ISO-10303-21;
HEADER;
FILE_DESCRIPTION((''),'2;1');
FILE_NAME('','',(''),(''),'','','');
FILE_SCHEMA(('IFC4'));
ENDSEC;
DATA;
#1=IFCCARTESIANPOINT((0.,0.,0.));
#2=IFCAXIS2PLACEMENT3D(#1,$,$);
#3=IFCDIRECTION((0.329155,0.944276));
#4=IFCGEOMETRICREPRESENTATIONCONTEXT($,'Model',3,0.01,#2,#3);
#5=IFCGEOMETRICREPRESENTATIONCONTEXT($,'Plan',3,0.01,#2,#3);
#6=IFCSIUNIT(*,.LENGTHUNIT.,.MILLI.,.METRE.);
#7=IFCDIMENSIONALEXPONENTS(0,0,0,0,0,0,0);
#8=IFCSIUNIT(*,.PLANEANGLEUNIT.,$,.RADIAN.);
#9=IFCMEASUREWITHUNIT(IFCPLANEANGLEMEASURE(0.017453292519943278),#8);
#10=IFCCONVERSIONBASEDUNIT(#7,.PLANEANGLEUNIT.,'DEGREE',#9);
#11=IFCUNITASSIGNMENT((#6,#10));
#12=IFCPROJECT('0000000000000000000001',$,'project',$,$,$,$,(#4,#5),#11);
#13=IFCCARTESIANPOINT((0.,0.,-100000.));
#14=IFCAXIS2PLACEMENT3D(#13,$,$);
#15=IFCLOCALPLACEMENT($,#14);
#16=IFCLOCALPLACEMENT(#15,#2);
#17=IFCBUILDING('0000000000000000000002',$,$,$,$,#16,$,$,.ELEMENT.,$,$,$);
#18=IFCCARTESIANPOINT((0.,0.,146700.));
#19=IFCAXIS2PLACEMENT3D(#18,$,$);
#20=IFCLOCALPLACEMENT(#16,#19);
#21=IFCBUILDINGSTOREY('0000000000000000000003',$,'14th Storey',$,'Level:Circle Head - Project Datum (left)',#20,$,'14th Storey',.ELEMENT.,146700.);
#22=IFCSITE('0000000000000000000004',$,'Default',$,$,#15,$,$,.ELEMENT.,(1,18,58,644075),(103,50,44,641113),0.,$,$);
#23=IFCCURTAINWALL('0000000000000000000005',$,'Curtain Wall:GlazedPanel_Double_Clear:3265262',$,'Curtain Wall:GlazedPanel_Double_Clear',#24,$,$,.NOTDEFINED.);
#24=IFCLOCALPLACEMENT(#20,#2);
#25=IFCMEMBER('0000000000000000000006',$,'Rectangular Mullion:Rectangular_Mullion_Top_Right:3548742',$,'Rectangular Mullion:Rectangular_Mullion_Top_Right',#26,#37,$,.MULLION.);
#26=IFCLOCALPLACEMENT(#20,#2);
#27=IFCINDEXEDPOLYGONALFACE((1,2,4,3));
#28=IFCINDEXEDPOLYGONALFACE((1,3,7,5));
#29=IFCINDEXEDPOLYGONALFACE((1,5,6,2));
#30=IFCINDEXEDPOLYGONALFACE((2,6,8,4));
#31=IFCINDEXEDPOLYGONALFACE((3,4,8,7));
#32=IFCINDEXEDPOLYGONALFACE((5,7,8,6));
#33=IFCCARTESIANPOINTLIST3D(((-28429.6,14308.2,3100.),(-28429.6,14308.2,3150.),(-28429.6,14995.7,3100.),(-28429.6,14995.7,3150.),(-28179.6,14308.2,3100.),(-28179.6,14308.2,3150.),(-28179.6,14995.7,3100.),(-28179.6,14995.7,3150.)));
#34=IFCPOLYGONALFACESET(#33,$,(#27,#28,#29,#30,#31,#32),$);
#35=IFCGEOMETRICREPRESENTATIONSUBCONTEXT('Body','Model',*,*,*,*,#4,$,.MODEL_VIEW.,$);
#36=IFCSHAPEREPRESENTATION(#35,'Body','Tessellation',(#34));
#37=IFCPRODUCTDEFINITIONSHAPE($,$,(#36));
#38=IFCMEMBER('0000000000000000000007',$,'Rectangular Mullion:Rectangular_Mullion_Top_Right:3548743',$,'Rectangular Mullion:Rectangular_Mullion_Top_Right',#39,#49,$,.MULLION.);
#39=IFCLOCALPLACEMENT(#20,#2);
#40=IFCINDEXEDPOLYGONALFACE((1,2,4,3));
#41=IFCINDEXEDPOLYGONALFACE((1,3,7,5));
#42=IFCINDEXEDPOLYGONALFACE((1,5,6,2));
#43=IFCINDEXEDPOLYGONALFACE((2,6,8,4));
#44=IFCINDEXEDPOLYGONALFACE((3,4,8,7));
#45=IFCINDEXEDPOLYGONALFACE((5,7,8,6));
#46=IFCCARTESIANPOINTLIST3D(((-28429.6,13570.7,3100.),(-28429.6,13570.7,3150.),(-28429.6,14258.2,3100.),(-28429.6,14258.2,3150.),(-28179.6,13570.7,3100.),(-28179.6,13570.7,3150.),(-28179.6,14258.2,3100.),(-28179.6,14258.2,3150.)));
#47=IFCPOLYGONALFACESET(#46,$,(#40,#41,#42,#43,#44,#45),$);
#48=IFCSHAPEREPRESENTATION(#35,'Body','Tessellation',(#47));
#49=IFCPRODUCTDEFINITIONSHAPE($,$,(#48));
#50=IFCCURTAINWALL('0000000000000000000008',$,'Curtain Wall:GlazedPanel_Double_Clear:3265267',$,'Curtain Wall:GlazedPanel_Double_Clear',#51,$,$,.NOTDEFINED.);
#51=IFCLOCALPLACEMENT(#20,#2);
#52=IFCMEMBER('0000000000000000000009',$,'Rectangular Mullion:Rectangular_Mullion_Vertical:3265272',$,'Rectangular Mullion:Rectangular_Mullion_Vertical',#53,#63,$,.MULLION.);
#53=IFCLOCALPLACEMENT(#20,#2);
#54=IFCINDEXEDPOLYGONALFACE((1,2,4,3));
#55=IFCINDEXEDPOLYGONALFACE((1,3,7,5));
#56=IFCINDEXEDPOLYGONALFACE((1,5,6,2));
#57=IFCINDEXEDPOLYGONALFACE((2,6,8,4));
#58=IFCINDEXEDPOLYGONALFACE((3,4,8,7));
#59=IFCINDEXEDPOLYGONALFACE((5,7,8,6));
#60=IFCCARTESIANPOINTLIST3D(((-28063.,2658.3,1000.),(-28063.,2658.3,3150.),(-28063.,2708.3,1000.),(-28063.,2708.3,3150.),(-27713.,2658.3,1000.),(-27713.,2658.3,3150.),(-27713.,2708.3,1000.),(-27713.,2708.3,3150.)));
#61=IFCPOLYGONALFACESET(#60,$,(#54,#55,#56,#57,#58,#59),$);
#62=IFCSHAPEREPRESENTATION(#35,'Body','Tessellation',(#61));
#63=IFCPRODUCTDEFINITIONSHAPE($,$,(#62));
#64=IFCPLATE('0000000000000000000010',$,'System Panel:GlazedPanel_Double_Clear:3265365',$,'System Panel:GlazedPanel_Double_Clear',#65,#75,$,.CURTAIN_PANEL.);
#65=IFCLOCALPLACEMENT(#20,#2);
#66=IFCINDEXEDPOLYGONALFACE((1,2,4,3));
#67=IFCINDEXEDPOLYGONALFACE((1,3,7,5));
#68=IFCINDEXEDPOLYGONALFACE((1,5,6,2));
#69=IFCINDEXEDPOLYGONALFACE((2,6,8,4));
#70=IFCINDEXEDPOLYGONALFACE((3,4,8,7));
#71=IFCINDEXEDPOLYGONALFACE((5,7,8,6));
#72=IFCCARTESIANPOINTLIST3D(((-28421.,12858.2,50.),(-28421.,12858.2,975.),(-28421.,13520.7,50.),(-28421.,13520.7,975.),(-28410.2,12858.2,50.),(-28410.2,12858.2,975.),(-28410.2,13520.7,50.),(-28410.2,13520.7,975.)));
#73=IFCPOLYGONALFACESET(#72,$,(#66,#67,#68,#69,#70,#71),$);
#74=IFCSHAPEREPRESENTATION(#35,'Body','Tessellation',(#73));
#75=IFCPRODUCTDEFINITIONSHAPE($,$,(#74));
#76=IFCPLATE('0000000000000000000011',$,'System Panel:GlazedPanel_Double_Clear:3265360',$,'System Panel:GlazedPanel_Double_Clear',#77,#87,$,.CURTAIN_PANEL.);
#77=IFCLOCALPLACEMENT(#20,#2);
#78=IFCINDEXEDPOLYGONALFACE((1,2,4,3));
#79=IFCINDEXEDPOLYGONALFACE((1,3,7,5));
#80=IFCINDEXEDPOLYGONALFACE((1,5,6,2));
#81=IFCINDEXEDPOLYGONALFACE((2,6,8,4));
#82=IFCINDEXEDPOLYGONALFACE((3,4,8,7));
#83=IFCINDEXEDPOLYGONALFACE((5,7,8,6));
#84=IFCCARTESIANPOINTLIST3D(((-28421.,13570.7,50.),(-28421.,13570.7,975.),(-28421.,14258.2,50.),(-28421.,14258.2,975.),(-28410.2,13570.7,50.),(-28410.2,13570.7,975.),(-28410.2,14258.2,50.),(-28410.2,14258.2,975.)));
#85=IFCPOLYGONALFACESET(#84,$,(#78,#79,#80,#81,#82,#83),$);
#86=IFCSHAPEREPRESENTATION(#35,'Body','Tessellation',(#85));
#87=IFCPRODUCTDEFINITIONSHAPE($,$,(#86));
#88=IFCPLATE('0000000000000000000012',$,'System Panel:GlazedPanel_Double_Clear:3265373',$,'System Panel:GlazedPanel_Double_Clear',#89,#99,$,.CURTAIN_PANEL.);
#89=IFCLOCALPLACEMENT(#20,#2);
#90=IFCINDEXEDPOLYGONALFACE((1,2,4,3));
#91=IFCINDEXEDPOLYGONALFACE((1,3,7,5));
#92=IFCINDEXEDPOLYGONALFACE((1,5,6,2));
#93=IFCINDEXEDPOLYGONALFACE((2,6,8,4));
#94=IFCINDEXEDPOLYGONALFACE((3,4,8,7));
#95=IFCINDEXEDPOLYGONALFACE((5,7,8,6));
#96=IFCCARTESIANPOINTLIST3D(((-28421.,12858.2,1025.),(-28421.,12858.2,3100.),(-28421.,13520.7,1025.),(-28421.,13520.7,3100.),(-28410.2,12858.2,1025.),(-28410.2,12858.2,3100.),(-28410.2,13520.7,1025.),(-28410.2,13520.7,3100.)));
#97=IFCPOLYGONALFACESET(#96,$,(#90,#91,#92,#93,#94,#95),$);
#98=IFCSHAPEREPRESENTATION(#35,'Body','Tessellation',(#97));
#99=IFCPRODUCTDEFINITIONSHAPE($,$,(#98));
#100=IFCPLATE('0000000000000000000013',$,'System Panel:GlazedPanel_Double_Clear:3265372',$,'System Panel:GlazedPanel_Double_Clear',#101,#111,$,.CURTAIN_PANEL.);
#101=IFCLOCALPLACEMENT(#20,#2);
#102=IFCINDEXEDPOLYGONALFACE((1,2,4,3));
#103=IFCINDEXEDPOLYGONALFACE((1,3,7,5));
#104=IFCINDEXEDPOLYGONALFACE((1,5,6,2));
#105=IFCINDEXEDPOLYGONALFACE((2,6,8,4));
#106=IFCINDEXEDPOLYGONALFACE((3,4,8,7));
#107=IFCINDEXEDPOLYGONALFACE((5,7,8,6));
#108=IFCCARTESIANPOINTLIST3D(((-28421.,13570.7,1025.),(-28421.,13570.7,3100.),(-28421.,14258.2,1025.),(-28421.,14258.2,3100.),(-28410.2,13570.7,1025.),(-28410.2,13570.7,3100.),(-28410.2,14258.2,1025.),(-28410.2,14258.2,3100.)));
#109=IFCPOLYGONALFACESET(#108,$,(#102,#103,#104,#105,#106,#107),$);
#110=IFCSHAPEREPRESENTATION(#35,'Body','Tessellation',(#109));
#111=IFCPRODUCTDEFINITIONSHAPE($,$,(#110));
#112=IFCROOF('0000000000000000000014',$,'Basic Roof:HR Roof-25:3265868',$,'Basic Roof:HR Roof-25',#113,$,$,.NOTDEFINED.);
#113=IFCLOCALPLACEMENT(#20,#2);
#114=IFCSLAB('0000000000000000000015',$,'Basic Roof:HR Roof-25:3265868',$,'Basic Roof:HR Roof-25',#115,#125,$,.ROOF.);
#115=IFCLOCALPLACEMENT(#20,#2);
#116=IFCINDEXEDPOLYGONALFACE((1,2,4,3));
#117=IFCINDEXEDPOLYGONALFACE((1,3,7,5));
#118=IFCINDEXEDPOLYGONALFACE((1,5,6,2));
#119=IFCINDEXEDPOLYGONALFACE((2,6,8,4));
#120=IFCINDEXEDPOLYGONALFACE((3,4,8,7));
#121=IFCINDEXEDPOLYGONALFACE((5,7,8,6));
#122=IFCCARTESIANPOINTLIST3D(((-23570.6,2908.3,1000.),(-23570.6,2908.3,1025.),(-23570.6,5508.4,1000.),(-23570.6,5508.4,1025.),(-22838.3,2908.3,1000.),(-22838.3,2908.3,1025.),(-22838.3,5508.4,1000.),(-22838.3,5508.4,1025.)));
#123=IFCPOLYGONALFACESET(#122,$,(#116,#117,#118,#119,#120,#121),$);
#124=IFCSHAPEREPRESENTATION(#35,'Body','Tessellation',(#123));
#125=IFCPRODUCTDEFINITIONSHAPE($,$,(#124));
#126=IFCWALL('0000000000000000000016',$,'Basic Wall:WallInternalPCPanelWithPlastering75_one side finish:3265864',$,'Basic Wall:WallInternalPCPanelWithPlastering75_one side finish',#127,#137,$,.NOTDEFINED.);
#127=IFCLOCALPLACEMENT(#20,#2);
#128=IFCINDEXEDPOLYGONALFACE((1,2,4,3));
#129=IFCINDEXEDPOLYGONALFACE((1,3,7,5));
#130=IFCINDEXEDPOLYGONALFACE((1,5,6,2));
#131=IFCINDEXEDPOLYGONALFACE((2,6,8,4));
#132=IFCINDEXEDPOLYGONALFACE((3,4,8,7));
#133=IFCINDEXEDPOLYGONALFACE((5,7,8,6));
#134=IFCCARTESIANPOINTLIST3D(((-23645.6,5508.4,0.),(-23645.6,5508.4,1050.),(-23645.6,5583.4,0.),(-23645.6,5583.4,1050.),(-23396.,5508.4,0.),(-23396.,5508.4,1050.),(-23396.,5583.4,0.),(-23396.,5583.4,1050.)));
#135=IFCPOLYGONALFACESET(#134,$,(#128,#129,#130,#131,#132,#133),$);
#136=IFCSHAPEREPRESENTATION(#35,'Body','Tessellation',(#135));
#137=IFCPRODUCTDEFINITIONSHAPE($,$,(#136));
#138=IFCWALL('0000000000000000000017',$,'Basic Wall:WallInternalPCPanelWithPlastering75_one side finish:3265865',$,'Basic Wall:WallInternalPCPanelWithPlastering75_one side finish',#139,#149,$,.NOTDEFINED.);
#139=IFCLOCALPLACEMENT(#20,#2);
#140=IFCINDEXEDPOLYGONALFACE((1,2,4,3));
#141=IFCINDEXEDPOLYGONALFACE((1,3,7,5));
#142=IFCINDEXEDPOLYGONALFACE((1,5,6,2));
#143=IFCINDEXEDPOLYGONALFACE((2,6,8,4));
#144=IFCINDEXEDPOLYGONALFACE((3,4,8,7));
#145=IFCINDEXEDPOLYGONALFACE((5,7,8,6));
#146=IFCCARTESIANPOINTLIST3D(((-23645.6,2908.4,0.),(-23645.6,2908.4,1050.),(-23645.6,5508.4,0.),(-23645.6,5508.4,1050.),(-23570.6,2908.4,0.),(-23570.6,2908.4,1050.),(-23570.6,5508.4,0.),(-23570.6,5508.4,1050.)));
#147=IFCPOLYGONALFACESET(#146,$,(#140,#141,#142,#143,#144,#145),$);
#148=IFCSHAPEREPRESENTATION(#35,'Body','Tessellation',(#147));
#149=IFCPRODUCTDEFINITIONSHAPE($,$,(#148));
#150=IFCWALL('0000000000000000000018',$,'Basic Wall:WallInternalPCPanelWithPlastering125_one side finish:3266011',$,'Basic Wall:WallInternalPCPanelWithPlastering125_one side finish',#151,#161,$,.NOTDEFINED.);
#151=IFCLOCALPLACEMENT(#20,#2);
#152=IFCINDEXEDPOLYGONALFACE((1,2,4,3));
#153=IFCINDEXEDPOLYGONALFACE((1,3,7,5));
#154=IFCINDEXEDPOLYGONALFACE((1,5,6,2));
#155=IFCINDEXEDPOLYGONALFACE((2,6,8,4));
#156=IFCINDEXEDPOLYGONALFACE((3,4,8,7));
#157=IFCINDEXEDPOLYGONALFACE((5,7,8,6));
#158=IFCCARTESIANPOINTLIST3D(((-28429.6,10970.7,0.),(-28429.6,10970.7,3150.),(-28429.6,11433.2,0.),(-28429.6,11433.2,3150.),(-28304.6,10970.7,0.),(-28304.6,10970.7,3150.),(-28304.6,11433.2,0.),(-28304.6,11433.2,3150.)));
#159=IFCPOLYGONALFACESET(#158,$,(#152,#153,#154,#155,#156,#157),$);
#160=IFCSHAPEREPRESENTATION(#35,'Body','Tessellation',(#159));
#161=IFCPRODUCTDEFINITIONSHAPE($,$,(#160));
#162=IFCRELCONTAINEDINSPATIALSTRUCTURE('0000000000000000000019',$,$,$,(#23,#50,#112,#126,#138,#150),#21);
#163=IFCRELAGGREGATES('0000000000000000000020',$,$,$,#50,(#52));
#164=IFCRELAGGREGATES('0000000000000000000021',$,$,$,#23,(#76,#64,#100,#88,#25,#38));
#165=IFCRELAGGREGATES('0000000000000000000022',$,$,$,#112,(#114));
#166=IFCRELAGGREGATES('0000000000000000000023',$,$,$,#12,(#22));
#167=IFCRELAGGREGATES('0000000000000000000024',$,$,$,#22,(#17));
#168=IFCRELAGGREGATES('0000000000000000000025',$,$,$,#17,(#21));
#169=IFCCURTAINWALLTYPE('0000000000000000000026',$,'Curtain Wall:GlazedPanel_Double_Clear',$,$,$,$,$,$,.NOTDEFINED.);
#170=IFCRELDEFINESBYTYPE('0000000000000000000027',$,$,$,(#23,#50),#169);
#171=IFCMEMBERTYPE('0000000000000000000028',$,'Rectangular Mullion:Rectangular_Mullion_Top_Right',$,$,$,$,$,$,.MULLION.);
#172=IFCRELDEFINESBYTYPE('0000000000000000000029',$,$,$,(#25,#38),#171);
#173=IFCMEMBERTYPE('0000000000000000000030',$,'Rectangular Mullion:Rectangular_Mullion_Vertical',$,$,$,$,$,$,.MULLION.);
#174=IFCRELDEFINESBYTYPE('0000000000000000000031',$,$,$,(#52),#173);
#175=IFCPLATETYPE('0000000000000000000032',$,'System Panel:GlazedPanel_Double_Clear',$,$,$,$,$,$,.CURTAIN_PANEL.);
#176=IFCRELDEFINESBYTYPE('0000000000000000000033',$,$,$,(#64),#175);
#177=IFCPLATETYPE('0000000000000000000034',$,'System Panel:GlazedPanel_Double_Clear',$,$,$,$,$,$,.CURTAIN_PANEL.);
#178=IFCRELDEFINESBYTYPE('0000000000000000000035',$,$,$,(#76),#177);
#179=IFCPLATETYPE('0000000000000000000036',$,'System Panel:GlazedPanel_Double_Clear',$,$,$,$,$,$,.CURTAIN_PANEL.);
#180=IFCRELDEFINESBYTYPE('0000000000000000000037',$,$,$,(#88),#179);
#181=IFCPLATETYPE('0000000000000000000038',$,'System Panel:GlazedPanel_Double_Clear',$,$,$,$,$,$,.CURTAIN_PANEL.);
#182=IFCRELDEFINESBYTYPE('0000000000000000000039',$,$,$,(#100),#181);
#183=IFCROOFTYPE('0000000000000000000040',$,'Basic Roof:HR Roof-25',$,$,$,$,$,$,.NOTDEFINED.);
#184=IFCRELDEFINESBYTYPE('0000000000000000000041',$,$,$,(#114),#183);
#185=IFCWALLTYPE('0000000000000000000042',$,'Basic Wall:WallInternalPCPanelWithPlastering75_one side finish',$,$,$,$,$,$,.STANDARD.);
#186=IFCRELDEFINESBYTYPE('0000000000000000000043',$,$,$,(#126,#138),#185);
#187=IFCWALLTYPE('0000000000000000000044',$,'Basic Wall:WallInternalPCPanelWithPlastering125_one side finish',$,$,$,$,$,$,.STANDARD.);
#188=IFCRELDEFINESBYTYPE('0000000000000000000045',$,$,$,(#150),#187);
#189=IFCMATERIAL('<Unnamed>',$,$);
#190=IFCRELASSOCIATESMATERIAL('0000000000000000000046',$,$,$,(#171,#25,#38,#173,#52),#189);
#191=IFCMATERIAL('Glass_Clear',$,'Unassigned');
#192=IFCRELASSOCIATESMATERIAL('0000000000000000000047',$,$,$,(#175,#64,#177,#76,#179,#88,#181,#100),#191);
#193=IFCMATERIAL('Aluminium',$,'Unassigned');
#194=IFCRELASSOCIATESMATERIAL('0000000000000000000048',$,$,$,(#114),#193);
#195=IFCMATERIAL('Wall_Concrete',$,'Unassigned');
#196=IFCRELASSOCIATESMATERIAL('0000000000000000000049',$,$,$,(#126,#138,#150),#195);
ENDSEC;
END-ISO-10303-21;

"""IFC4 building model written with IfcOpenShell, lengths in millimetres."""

from ifc_helpers import new_model, entity, si_unit, converted_unit, direction, frame, origin, place, context, subcontext, project, spatial, indexed_curve, outline, extrude, source, transform, mapped, material, type_object, type_shapes, element, aggregate, save


model = new_model("IFC4")

# Units and contexts
model_context = context("Model", 3, precision=0.01, world=origin(), true_north=direction((0.329155, 0.944276)))
plan_context = context("Plan", 3, precision=0.01, world=origin(), true_north=direction((0.329155, 0.944276)))
body_context = subcontext(model_context, "Body", "Model", "MODEL_VIEW")
ifc_project = project(units=[si_unit("LENGTHUNIT", "METRE", prefix="MILLI"), converted_unit("PLANEANGLEUNIT", "DEGREE", entity("IfcPlaneAngleMeasure", 0.017453292519943278), si_unit("PLANEANGLEUNIT", "RADIAN"), dimensions=[0, 0, 0, 0, 0, 0, 0])], contexts=[model_context, plan_context])

# Site, building, storey
site_placement = place(None, frame((0.0, 0.0, -100000.0)))
site = spatial("IfcSite", under=ifc_project, at=site_placement, Name="Default", CompositionType="ELEMENT", RefLatitude=(1, 18, 58, 644075), RefLongitude=(103, 50, 44, 641113), RefElevation=0.0)
building_placement = place(site_placement, origin())
building = spatial("IfcBuilding", under=site, at=building_placement, CompositionType="ELEMENT")
storey_placement = place(building_placement, frame((0.0, 0.0, 146700.0)))
storey = spatial("IfcBuildingStorey", under=building, at=storey_placement, Name="14th Storey", ObjectType="Level:Circle Head - Project Datum (left)", LongName="14th Storey", CompositionType="ELEMENT", Elevation=146700.0)

# Curtain wall, members
curtain_wall_type = type_object("IfcCurtainWallType", Name="Curtain Wall:GlazedPanel_Double_Clear", PredefinedType="NOTDEFINED")
ifc_material_1 = material(Name="<Unnamed>")
curtain_wall_1_placement = place(storey_placement, frame((0.0, 0.0, -146700.0)))
curtain_wall_1 = element("IfcCurtainWall", 1, at=curtain_wall_1_placement, inside=storey, type_object=curtain_wall_type, Name="Curtain Wall:GlazedPanel_Double_Clear:3265262", ObjectType="Curtain Wall:GlazedPanel_Double_Clear", PredefinedType="NOTDEFINED")
member_type_1 = type_object("IfcMemberType", Name="Rectangular Mullion:Rectangular_Mullion_Top_Right", PredefinedType="MULLION", material=ifc_material_1)
shared_shape_1 = source(origin(), body_context, "Body", "SweptSolid", [
    extrude(outline(indexed_curve([(-25.0, -125.0), (25.0, -125.0), (25.0, 125.0), (-25.0, 125.0), (-25.0, -125.0)], self_intersect=False)), frame((-25.0, 0.0, -687.5), z_axis=(0.0, 0.0, 1.0), x_axis=(-1.0, 0.0, 0.0)), (0.0, 0.0, 1.0), 687.5),
])
type_shapes(member_type_1, [shared_shape_1])
member_1_placement = place(curtain_wall_1_placement, frame((-28304.6, 14308.2, 149850.0), z_axis=(0.0, -1.0, 0.0), x_axis=(0.0, 0.0, 1.0)))
member_1 = element("IfcMember", 2, at=member_1_placement, type_object=member_type_1, material=ifc_material_1, Name="Rectangular Mullion:Rectangular_Mullion_Top_Right:3548742", ObjectType="Rectangular Mullion:Rectangular_Mullion_Top_Right", PredefinedType="MULLION", context=body_context, shape_type="MappedRepresentation", body=[
    mapped(shared_shape_1, transform((0.0, 0.0, 0.0), scale=1.0)),
])
member_2_placement = place(curtain_wall_1_placement, frame((-28304.6, 13570.7, 149850.0), z_axis=(0.0, -1.0, 0.0), x_axis=(0.0, 0.0, 1.0)))
member_2 = element("IfcMember", 3, at=member_2_placement, type_object=member_type_1, material=ifc_material_1, Name="Rectangular Mullion:Rectangular_Mullion_Top_Right:3548743", ObjectType="Rectangular Mullion:Rectangular_Mullion_Top_Right", PredefinedType="MULLION", context=body_context, shape_type="MappedRepresentation", body=[
    mapped(shared_shape_1, transform((0.0, 0.0, 0.0), scale=1.0)),
])

# Curtain wall, member
curtain_wall_2_placement = place(storey_placement, frame((0.0, 0.0, -146700.0)))
curtain_wall_2 = element("IfcCurtainWall", 4, at=curtain_wall_2_placement, inside=storey, type_object=curtain_wall_type, Name="Curtain Wall:GlazedPanel_Double_Clear:3265267", ObjectType="Curtain Wall:GlazedPanel_Double_Clear", PredefinedType="NOTDEFINED")
member_type_2 = type_object("IfcMemberType", Name="Rectangular Mullion:Rectangular_Mullion_Vertical", PredefinedType="MULLION", material=ifc_material_1)
shared_shape_2 = source(origin(), body_context, "Body", "SweptSolid", [
    extrude(outline(indexed_curve([(-25.0, -175.0), (25.0, -175.0), (25.0, 175.0), (-25.0, 175.0), (-25.0, -175.0)], self_intersect=False)), frame((-25.0, 50.0, -2150.0), z_axis=(0.0, 0.0, 1.0), x_axis=(-1.0, 0.0, 0.0)), (0.0, 0.0, 1.0), 2150.0),
])
type_shapes(member_type_2, [shared_shape_2])
member_3_placement = place(curtain_wall_2_placement, frame((-27838.0, 2708.3, 149850.0), z_axis=(0.0, 0.0, 1.0), x_axis=(0.0, 1.0, 0.0)))
member_3 = element("IfcMember", 5, at=member_3_placement, type_object=member_type_2, material=ifc_material_1, Name="Rectangular Mullion:Rectangular_Mullion_Vertical:3265272", ObjectType="Rectangular Mullion:Rectangular_Mullion_Vertical", PredefinedType="MULLION", context=body_context, shape_type="MappedRepresentation", body=[
    mapped(shared_shape_2, transform((0.0, 0.0, 0.0), scale=1.0)),
])
aggregate(curtain_wall_2, [member_3])

# Plates
ifc_material_2 = material(Name="Glass_Clear", Category="Unassigned")
plate_type_1 = type_object("IfcPlateType", Name="System Panel:GlazedPanel_Double_Clear", PredefinedType="CURTAIN_PANEL", material=ifc_material_2)
shared_shape_3 = source(origin(), body_context, "Body", "SweptSolid", [
    extrude(outline(indexed_curve([(-5.4, -331.3), (5.4, -331.3), (5.4, 331.3), (-5.4, 331.3), (-5.4, -331.3)], self_intersect=False)), frame((331.3, 5.4, 0.0), z_axis=(0.0, 0.0, 1.0), x_axis=(0.0, 1.0, 0.0)), (0.0, 0.0, 1.0), 925.0),
])
type_shapes(plate_type_1, [shared_shape_3])
plate_1_placement = place(curtain_wall_1_placement, frame((-28421.0, 13520.7, 146750.0), z_axis=(0.0, 0.0, 1.0), x_axis=(0.0, -1.0, 0.0)))
plate_1 = element("IfcPlate", 6, at=plate_1_placement, type_object=plate_type_1, material=ifc_material_2, Name="System Panel:GlazedPanel_Double_Clear:3265365", ObjectType="System Panel:GlazedPanel_Double_Clear", PredefinedType="CURTAIN_PANEL", context=body_context, shape_type="MappedRepresentation", body=[
    mapped(shared_shape_3, transform((0.0, 0.0, 0.0), scale=1.0)),
])
plate_type_2 = type_object("IfcPlateType", Name="System Panel:GlazedPanel_Double_Clear", PredefinedType="CURTAIN_PANEL", material=ifc_material_2)
shared_shape_4 = source(origin(), body_context, "Body", "SweptSolid", [
    extrude(outline(indexed_curve([(-5.4, -343.7), (5.4, -343.7), (5.4, 343.7), (-5.4, 343.7), (-5.4, -343.7)], self_intersect=False)), frame((343.7, 5.4, 0.0), z_axis=(0.0, 0.0, 1.0), x_axis=(0.0, 1.0, 0.0)), (0.0, 0.0, 1.0), 925.0),
])
type_shapes(plate_type_2, [shared_shape_4])
plate_2_placement = place(curtain_wall_1_placement, frame((-28421.0, 14258.2, 146750.0), z_axis=(0.0, 0.0, 1.0), x_axis=(0.0, -1.0, 0.0)))
plate_2 = element("IfcPlate", 7, at=plate_2_placement, type_object=plate_type_2, material=ifc_material_2, Name="System Panel:GlazedPanel_Double_Clear:3265360", ObjectType="System Panel:GlazedPanel_Double_Clear", PredefinedType="CURTAIN_PANEL", context=body_context, shape_type="MappedRepresentation", body=[
    mapped(shared_shape_4, transform((0.0, 0.0, 0.0), scale=1.0)),
])
plate_type_3 = type_object("IfcPlateType", Name="System Panel:GlazedPanel_Double_Clear", PredefinedType="CURTAIN_PANEL", material=ifc_material_2)
shared_shape_5 = source(origin(), body_context, "Body", "SweptSolid", [
    extrude(outline(indexed_curve([(-5.4, -331.3), (5.4, -331.3), (5.4, 331.3), (-5.4, 331.3), (-5.4, -331.3)], self_intersect=False)), frame((331.3, 5.4, 0.0), z_axis=(0.0, 0.0, 1.0), x_axis=(0.0, 1.0, 0.0)), (0.0, 0.0, 1.0), 2075.0),
])
type_shapes(plate_type_3, [shared_shape_5])
plate_3_placement = place(curtain_wall_1_placement, frame((-28421.0, 13520.7, 147725.0), z_axis=(0.0, 0.0, 1.0), x_axis=(0.0, -1.0, 0.0)))
plate_3 = element("IfcPlate", 8, at=plate_3_placement, type_object=plate_type_3, material=ifc_material_2, Name="System Panel:GlazedPanel_Double_Clear:3265373", ObjectType="System Panel:GlazedPanel_Double_Clear", PredefinedType="CURTAIN_PANEL", context=body_context, shape_type="MappedRepresentation", body=[
    mapped(shared_shape_5, transform((0.0, 0.0, 0.0), scale=1.0)),
])
plate_type_4 = type_object("IfcPlateType", Name="System Panel:GlazedPanel_Double_Clear", PredefinedType="CURTAIN_PANEL", material=ifc_material_2)
shared_shape_6 = source(origin(), body_context, "Body", "SweptSolid", [
    extrude(outline(indexed_curve([(-5.4, -343.7), (5.4, -343.7), (5.4, 343.7), (-5.4, 343.7), (-5.4, -343.7)], self_intersect=False)), frame((343.7, 5.4, 0.0), z_axis=(0.0, 0.0, 1.0), x_axis=(0.0, 1.0, 0.0)), (0.0, 0.0, 1.0), 2075.0),
])
type_shapes(plate_type_4, [shared_shape_6])
plate_4_placement = place(curtain_wall_1_placement, frame((-28421.0, 14258.2, 147725.0), z_axis=(0.0, 0.0, 1.0), x_axis=(0.0, -1.0, 0.0)))
plate_4 = element("IfcPlate", 9, at=plate_4_placement, type_object=plate_type_4, material=ifc_material_2, Name="System Panel:GlazedPanel_Double_Clear:3265372", ObjectType="System Panel:GlazedPanel_Double_Clear", PredefinedType="CURTAIN_PANEL", context=body_context, shape_type="MappedRepresentation", body=[
    mapped(shared_shape_6, transform((0.0, 0.0, 0.0), scale=1.0)),
])
aggregate(curtain_wall_1, [plate_2, plate_1, plate_4, plate_3, member_1, member_2])

# Roof, slab
roof_placement = place(storey_placement, frame((-23570.6, 2908.3, 1000.0)))
roof = element("IfcRoof", 10, at=roof_placement, inside=storey, Name="Basic Roof:HR Roof-25:3265868", ObjectType="Basic Roof:HR Roof-25", PredefinedType="NOTDEFINED")
ifc_material_3 = material(Name="Aluminium", Category="Unassigned")
roof_type = type_object("IfcRoofType", Name="Basic Roof:HR Roof-25", PredefinedType="NOTDEFINED")
slab_placement = place(roof_placement, origin())
slab = element("IfcSlab", 11, at=slab_placement, type_object=roof_type, material=ifc_material_3, Name="Basic Roof:HR Roof-25:3265868", ObjectType="Basic Roof:HR Roof-25", PredefinedType="ROOF", context=body_context, shape_type="SweptSolid", body=[
    extrude(outline(indexed_curve([(-366.1, 1300.1), (-366.1, -1300.1), (366.1, -1300.1), (366.1, 1300.1), (-366.1, 1300.1)], self_intersect=False)), frame((366.1, 1300.1, 0.0)), (0.0, 0.0, 1.0), 25.0),
])
aggregate(roof, [slab])

# Walls
ifc_material_4 = material(Name="Wall_Concrete", Category="Unassigned")
wall_type_1 = type_object("IfcWallType", Name="Basic Wall:WallInternalPCPanelWithPlastering75_one side finish", PredefinedType="STANDARD")
wall_1_placement = place(storey_placement, frame((-23396.0, 5545.9, 0.0), z_axis=(0.0, 0.0, 1.0), x_axis=(-1.0, 0.0, 0.0)))
element("IfcWall", 12, at=wall_1_placement, inside=storey, type_object=wall_type_1, material=ifc_material_4, Name="Basic Wall:WallInternalPCPanelWithPlastering75_one side finish:3265864", ObjectType="Basic Wall:WallInternalPCPanelWithPlastering75_one side finish", PredefinedType="NOTDEFINED", context=body_context, shape_type="SweptSolid", body=[
    extrude(outline(indexed_curve([(249.6, 37.5), (0.0, 37.5), (0.0, -37.5), (249.6, -37.5), (249.6, 37.5)], self_intersect=False)), origin(), (0.0, 0.0, 1.0), 1050.0),
])
wall_2_placement = place(storey_placement, frame((-23608.1, 5508.4, 0.0), z_axis=(0.0, 0.0, 1.0), x_axis=(0.0, -1.0, 0.0)))
element("IfcWall", 13, at=wall_2_placement, inside=storey, type_object=wall_type_1, material=ifc_material_4, Name="Basic Wall:WallInternalPCPanelWithPlastering75_one side finish:3265865", ObjectType="Basic Wall:WallInternalPCPanelWithPlastering75_one side finish", PredefinedType="NOTDEFINED", context=body_context, shape_type="SweptSolid", body=[
    extrude(outline(indexed_curve([(2600.0, 37.5), (0.0, 37.5), (0.0, -37.5), (2600.0, -37.5), (2600.0, 37.5)], self_intersect=False)), origin(), (0.0, 0.0, 1.0), 1050.0),
])
wall_type_2 = type_object("IfcWallType", Name="Basic Wall:WallInternalPCPanelWithPlastering125_one side finish", PredefinedType="STANDARD")
wall_3_placement = place(storey_placement, frame((-28367.1, 10970.7, 0.0), z_axis=(0.0, 0.0, 1.0), x_axis=(0.0, 1.0, 0.0)))
element("IfcWall", 14, at=wall_3_placement, inside=storey, type_object=wall_type_2, material=ifc_material_4, Name="Basic Wall:WallInternalPCPanelWithPlastering125_one side finish:3266011", ObjectType="Basic Wall:WallInternalPCPanelWithPlastering125_one side finish", PredefinedType="NOTDEFINED", context=body_context, shape_type="SweptSolid", body=[
    extrude(outline(indexed_curve([(462.5, 62.5), (0.0, 62.5), (0.0, -62.5), (462.5, -62.5), (462.5, 62.5)], self_intersect=False)), origin(), (0.0, 0.0, 1.0), 3150.0),
])

save(model, "model.ifc")
